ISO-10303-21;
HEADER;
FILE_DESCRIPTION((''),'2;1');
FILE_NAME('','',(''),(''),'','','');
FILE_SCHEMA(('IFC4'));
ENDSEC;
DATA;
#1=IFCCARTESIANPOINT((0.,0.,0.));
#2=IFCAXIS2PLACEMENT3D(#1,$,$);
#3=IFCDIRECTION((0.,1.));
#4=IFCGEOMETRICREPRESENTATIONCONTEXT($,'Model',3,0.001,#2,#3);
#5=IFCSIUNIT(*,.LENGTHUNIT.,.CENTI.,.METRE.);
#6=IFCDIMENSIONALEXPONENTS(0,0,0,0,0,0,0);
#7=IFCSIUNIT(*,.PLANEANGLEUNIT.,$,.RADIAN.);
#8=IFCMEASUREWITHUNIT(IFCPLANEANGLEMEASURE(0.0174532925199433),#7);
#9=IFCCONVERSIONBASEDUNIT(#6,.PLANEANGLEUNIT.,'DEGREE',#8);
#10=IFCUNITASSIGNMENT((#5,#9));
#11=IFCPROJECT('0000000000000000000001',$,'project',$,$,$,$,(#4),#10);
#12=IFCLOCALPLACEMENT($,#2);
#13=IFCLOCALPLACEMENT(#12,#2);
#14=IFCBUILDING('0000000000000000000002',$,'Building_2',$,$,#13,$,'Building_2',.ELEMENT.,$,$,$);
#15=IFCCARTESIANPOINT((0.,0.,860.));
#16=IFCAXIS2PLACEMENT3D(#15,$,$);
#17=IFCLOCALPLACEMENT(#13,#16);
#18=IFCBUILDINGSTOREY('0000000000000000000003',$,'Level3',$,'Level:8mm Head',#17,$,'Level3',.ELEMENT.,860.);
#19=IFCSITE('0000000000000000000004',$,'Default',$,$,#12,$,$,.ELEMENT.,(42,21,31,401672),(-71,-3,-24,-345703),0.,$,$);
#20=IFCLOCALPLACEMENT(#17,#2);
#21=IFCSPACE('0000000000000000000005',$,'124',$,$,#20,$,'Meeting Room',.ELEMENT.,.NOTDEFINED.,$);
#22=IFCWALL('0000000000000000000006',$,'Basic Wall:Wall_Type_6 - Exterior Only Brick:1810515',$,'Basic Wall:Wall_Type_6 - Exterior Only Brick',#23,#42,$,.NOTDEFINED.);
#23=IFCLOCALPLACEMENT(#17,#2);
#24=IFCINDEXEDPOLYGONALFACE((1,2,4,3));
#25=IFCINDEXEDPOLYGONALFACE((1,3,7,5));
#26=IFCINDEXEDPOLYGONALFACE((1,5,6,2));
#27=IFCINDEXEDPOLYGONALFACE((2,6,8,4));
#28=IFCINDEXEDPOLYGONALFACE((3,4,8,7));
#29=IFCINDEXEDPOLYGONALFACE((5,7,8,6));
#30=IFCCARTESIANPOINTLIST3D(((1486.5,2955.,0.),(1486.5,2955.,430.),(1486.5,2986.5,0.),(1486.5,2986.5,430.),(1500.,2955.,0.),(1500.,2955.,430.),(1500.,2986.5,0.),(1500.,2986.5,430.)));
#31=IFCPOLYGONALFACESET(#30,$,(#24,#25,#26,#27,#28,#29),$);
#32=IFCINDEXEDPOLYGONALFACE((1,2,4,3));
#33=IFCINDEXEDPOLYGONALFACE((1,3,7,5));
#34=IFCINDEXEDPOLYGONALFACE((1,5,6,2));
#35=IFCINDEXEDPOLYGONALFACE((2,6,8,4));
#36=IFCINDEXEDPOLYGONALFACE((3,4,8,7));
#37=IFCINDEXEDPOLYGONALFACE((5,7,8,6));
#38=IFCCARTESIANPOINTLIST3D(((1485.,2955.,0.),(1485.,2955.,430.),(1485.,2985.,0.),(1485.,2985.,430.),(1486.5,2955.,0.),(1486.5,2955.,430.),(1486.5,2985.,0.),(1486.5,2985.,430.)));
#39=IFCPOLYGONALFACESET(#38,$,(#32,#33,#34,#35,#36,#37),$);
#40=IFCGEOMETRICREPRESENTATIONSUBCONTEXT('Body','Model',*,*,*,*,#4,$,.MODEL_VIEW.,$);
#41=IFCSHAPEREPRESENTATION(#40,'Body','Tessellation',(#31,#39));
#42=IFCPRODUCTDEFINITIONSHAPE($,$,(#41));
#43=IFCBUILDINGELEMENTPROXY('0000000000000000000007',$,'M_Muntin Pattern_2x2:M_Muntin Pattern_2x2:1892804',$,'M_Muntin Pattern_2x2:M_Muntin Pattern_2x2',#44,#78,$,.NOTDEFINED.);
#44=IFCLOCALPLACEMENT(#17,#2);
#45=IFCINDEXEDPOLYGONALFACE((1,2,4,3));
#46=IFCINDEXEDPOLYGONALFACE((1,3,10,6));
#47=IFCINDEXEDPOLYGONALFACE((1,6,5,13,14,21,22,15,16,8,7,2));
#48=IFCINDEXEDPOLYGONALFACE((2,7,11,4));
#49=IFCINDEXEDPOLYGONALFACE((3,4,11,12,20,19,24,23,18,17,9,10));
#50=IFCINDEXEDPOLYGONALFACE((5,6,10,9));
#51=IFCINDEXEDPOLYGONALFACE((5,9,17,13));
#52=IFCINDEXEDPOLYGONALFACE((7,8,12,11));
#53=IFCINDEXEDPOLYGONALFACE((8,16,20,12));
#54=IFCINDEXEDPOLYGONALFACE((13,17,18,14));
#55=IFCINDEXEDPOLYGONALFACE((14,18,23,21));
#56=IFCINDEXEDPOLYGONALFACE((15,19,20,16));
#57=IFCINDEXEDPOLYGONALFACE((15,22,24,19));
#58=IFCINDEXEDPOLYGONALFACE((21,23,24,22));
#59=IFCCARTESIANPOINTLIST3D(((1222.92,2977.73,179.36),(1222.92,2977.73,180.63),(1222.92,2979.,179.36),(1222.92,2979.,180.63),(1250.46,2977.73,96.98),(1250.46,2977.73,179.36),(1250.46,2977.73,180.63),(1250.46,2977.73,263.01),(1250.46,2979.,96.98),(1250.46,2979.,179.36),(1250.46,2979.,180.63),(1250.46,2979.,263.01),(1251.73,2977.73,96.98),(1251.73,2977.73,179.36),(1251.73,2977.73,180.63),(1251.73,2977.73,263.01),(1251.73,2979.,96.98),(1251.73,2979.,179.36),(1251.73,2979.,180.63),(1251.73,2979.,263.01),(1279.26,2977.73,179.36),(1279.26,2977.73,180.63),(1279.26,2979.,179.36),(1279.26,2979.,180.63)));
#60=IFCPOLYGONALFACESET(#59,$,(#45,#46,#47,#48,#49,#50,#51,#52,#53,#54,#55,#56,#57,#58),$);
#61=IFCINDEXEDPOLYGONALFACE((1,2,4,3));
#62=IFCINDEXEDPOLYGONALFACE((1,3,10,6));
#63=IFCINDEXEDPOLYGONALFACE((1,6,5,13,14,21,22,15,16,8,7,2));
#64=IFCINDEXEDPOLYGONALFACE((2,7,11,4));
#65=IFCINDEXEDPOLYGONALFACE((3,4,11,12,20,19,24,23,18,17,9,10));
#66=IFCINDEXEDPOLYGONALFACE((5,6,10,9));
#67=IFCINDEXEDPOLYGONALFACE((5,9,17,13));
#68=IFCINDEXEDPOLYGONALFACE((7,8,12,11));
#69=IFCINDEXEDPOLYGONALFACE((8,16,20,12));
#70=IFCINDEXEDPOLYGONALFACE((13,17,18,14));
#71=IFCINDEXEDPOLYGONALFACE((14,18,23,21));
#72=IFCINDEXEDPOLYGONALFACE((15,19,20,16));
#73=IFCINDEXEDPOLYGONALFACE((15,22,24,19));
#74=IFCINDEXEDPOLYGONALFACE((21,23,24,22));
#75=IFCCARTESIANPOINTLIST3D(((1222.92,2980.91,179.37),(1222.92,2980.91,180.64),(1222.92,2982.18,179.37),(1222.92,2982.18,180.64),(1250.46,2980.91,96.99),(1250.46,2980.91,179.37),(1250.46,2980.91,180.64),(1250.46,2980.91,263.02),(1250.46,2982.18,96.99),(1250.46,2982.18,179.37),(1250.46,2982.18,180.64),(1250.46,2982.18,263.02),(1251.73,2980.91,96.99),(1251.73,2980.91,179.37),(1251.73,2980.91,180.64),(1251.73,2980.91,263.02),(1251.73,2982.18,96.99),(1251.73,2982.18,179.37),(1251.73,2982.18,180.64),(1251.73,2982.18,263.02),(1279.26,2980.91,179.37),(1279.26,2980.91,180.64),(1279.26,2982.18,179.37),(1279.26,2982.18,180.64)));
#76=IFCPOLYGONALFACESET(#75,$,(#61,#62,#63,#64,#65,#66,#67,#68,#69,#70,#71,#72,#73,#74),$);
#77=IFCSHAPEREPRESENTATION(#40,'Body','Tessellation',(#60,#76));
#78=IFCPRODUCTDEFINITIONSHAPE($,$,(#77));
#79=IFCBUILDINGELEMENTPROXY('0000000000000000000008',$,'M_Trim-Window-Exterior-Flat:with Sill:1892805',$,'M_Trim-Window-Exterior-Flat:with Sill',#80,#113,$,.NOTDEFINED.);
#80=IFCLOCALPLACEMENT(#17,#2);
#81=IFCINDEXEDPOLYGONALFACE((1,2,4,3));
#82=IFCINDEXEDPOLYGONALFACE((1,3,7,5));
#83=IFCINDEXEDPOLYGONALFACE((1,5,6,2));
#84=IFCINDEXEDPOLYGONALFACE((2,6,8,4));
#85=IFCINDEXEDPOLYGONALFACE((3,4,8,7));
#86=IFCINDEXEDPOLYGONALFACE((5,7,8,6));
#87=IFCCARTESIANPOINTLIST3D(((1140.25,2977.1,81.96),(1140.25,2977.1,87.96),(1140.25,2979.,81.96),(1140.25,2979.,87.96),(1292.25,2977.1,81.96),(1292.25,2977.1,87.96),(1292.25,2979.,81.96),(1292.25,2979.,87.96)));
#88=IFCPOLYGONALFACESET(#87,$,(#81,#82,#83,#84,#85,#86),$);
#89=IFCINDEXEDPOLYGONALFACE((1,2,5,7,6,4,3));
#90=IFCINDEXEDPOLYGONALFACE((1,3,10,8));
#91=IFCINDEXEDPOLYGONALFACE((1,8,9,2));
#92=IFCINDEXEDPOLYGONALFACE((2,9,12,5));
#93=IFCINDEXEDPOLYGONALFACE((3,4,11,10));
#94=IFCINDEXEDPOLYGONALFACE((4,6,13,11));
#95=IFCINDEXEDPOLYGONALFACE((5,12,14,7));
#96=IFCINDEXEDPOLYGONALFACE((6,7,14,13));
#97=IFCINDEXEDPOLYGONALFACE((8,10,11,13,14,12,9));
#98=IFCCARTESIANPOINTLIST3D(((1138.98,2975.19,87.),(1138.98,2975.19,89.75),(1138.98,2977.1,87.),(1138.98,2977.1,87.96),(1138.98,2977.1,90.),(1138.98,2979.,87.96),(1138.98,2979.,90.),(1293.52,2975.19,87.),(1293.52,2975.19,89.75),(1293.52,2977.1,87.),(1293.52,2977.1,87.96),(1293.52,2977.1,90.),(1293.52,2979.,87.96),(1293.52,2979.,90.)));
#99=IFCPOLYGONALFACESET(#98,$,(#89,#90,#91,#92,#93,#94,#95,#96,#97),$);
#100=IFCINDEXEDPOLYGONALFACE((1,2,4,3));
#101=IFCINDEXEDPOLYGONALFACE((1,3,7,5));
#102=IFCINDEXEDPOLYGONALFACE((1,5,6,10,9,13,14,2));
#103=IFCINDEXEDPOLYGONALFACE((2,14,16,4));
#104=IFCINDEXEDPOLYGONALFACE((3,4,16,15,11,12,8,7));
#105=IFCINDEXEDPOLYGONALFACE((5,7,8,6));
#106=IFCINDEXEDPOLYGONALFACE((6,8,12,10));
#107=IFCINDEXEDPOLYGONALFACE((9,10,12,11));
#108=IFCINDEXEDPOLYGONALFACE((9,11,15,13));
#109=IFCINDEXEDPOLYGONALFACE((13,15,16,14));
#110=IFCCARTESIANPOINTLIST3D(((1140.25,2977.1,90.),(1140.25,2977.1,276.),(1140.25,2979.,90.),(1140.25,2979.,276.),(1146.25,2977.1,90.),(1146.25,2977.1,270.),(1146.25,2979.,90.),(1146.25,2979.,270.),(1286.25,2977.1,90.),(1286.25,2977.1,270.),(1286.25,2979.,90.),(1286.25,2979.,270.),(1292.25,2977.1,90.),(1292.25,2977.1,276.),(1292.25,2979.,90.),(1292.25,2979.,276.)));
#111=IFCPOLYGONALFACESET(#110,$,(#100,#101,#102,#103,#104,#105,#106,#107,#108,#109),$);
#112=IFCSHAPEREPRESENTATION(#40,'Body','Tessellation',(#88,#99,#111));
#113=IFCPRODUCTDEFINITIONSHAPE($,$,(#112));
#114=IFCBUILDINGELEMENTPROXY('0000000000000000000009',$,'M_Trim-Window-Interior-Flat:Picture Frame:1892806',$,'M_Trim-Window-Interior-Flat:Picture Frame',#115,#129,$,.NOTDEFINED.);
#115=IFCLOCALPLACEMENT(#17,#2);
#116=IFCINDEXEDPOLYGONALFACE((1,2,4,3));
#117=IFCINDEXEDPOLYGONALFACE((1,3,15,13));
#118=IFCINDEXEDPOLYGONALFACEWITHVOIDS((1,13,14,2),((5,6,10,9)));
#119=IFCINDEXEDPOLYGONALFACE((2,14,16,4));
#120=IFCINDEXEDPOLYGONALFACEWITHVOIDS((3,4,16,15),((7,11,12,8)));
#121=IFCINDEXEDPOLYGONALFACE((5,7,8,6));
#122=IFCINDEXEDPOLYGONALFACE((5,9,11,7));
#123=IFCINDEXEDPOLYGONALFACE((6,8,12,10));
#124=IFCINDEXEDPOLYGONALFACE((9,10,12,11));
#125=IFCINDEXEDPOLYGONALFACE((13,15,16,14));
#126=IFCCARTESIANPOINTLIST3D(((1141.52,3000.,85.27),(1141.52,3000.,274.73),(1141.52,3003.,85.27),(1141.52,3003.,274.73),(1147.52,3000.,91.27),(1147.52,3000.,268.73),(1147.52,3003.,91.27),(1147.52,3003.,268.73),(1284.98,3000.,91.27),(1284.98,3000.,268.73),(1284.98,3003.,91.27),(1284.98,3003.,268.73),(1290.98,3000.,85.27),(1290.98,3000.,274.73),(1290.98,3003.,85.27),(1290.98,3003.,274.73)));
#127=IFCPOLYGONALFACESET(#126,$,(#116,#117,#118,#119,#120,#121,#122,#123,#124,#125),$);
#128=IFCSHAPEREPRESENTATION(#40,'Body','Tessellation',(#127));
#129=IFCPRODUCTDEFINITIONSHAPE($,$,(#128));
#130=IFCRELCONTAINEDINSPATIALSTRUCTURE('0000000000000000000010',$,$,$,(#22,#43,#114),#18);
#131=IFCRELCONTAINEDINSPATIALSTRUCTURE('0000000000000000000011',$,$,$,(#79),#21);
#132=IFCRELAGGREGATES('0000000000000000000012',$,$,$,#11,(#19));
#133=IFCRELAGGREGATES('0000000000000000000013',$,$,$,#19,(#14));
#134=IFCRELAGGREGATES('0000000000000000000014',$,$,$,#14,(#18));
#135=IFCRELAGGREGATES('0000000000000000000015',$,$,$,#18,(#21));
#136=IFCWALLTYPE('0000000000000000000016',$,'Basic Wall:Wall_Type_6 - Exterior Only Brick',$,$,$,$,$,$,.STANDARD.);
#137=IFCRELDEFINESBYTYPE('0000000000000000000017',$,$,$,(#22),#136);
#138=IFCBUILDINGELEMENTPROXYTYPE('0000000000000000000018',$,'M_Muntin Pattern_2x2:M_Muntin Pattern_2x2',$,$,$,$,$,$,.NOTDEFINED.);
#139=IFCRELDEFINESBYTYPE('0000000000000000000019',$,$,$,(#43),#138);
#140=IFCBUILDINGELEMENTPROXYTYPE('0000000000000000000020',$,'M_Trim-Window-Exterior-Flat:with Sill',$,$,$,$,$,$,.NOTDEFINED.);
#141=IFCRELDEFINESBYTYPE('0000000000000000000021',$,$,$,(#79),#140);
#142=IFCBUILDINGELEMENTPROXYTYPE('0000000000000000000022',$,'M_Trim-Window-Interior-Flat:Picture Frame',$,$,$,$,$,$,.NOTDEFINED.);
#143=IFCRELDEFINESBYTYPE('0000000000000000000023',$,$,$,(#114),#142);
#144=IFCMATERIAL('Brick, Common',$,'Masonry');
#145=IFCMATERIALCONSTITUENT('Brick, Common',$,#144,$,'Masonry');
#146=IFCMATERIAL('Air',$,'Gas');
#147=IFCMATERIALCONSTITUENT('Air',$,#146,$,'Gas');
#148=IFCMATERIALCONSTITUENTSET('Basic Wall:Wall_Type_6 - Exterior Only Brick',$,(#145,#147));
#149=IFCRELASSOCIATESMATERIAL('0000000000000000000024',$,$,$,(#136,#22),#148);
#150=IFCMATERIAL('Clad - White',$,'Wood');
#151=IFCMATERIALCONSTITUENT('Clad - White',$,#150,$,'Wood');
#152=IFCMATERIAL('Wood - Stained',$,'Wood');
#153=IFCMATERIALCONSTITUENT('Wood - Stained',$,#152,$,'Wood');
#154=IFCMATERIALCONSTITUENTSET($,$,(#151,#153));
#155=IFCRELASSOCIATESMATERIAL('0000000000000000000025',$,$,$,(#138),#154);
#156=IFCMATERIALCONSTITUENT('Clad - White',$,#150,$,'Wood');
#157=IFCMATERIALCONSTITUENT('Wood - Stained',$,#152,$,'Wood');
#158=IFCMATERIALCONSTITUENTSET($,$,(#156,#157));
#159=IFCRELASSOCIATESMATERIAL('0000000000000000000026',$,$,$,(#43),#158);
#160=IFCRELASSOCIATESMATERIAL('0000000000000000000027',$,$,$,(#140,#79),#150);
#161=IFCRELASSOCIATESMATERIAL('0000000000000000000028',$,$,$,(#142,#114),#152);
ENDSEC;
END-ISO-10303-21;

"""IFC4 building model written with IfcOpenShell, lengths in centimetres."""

from ifc_helpers import new_model, entity, si_unit, converted_unit, direction, frame, origin, place, context, subcontext, project, spatial, indexed_curve, outline, extrude, source, transform, mapped, material, constituent, constituent_set, type_object, type_shapes, element, save


model = new_model("IFC4")

# Units and contexts
model_context = context("Model", 3, precision=0.001, world=origin(), true_north=direction((0.0, 1.0)))
body_context = subcontext(model_context, "Body", "Model", "MODEL_VIEW")
ifc_project = project(units=[si_unit("LENGTHUNIT", "METRE", prefix="CENTI"), converted_unit("PLANEANGLEUNIT", "DEGREE", entity("IfcPlaneAngleMeasure", 0.0174532925199433), si_unit("PLANEANGLEUNIT", "RADIAN"), dimensions=[0, 0, 0, 0, 0, 0, 0])], contexts=[model_context])

# Site, building, storey
site_placement = place(None, origin())
site = spatial("IfcSite", under=ifc_project, at=site_placement, Name="Default", CompositionType="ELEMENT", RefLatitude=(42, 21, 31, 401672), RefLongitude=(-71, -3, -24, -345703), RefElevation=0.0)
building_placement = place(site_placement, origin())
building = spatial("IfcBuilding", under=site, at=building_placement, Name="Building_2", LongName="Building_2", CompositionType="ELEMENT")
storey_placement = place(building_placement, frame((0.0, 0.0, 860.0)))
storey = spatial("IfcBuildingStorey", under=building, at=storey_placement, Name="Level3", ObjectType="Level:8mm Head", LongName="Level3", CompositionType="ELEMENT", Elevation=860.0)

# Wall
ifc_material_1 = material(Name="Brick, Common", Category="Masonry")
ifc_constituent_1 = constituent(ifc_material_1, Name="Brick, Common", Category="Masonry")
ifc_material_2 = material(Name="Air", Category="Gas")
ifc_constituent_2 = constituent(ifc_material_2, Name="Air", Category="Gas")
ifc_constituent_set_1 = constituent_set(constituents=[ifc_constituent_1, ifc_constituent_2], Name="Basic Wall:Wall_Type_6 - Exterior Only Brick")
wall_type = type_object("IfcWallType", Name="Basic Wall:Wall_Type_6 - Exterior Only Brick", PredefinedType="STANDARD", material=ifc_constituent_set_1)
wall_1_placement = place(storey_placement, frame((1492.5, 2985.0, 0.0), z_axis=(0.0, 0.0, 1.0), x_axis=(0.0, -1.0, 0.0)))
element("IfcWall", 1, at=wall_1_placement, inside=storey, type_object=wall_type, material=ifc_constituent_set_1, Name="Basic Wall:Wall_Type_6 - Exterior Only Brick:1810515", ObjectType="Basic Wall:Wall_Type_6 - Exterior Only Brick", PredefinedType="NOTDEFINED", context=body_context, shape_type="SweptSolid", body=[
    extrude(outline(indexed_curve([(-6.75, -15.75), (6.75, -15.75), (6.75, 15.75), (-6.75, 15.75), (-6.75, -15.75)], self_intersect=False)), frame((14.25, 0.75, 0.0), z_axis=(0.0, 0.0, 1.0), x_axis=(0.0, -1.0, 0.0)), (0.0, 0.0, 1.0), 430.0),
    extrude(outline(indexed_curve([(-0.75, -15.0), (0.75, -15.0), (0.75, 15.0), (-0.75, 15.0), (-0.75, -15.0)], self_intersect=False)), frame((15.0, -6.75, 0.0), z_axis=(0.0, 0.0, 1.0), x_axis=(0.0, 1.0, 0.0)), (0.0, 0.0, 1.0), 430.0),
])

# Building element proxy
ifc_material_3 = material(Name="Clad - White", Category="Wood")
ifc_constituent_3 = constituent(ifc_material_3, Name="Clad - White", Category="Wood")
ifc_material_4 = material(Name="Wood - Stained", Category="Wood")
ifc_constituent_4 = constituent(ifc_material_4, Name="Wood - Stained", Category="Wood")
ifc_constituent_set_2 = constituent_set(constituents=[ifc_constituent_3, ifc_constituent_4])
ifc_constituent_5 = constituent(ifc_material_3, Name="Clad - White", Category="Wood")
ifc_constituent_6 = constituent(ifc_material_4, Name="Wood - Stained", Category="Wood")
ifc_constituent_set_3 = constituent_set(constituents=[ifc_constituent_5, ifc_constituent_6])
building_element_proxy_type_1 = type_object("IfcBuildingElementProxyType", Name="M_Muntin Pattern_2x2:M_Muntin Pattern_2x2", PredefinedType="NOTDEFINED", material=ifc_constituent_set_3)
shared_shape_1 = source(origin(), body_context, "Body", "SweptSolid", [
    extrude(outline(indexed_curve([(0.64, -0.64), (83.01, -0.64), (83.01, 0.63), (0.64, 0.63), (0.64, 28.17), (-0.63, 28.17), (-0.63, 0.63), (-83.02, 0.63), (-83.02, -0.64), (-0.63, -0.64), (-0.63, -28.17), (0.64, -28.17), (0.64, -0.64)], self_intersect=False)), frame((0.0, 0.95, 83.01), z_axis=(0.0, 1.0, 0.0), x_axis=(0.0, 0.0, 1.0)), (0.0, 0.0, 1.0), 1.27),
    extrude(outline(indexed_curve([(0.64, -0.64), (83.02, -0.64), (83.02, 0.63), (0.64, 0.63), (0.64, 28.17), (-0.63, 28.17), (-0.63, 0.63), (-83.02, 0.63), (-83.02, -0.64), (-0.63, -0.64), (-0.63, -28.17), (0.64, -28.17), (0.64, -0.64)], self_intersect=False)), frame((0.0, -2.22, 83.02), z_axis=(0.0, 1.0, 0.0), x_axis=(0.0, 0.0, 1.0)), (0.0, 0.0, 1.0), 1.27),
])
type_shapes(building_element_proxy_type_1, [shared_shape_1])
proxy_1_placement = place(storey_placement, frame((1251.09, 2979.95, 96.99), z_axis=(0.0, 0.0, 1.0), x_axis=(-1.0, 0.0, 0.0)))
element("IfcBuildingElementProxy", 2, at=proxy_1_placement, inside=storey, type_object=building_element_proxy_type_1, material=ifc_constituent_set_2, Name="M_Muntin Pattern_2x2:M_Muntin Pattern_2x2:1892804", ObjectType="M_Muntin Pattern_2x2:M_Muntin Pattern_2x2", PredefinedType="NOTDEFINED", context=body_context, shape_type="MappedRepresentation", body=[
    mapped(shared_shape_1, transform((0.0, 0.0, 0.0), scale=1.0)),
])

# Shared definitions
space_placement = place(storey_placement, origin())
space = spatial("IfcSpace", under=storey, at=space_placement, Name="124", LongName="Meeting Room", CompositionType="ELEMENT", PredefinedType="NOTDEFINED")

# Building element proxies
building_element_proxy_type_2 = type_object("IfcBuildingElementProxyType", Name="M_Trim-Window-Exterior-Flat:with Sill", PredefinedType="NOTDEFINED", material=ifc_material_3)
shared_shape_2 = source(origin(), body_context, "Body", "SweptSolid", [
    extrude(outline(indexed_curve([(-3.0, -76.0), (3.0, -76.0), (3.0, 76.0), (-3.0, 76.0), (-3.0, -76.0)], self_intersect=False)), frame((0.0, 185.04, 0.0), z_axis=(0.0, 0.0, 1.0), x_axis=(0.0, 1.0, 0.0)), (0.0, 0.0, 1.0), 1.91),
    extrude(outline(indexed_curve([(-1.52, -1.9), (1.23, -1.9), (1.48, 0.0), (1.48, 1.9), (-0.57, 1.9), (-0.57, 0.0), (-1.52, 0.0), (-1.52, -1.9)], self_intersect=False)), frame((-77.27, 181.48, 1.9), z_axis=(1.0, 0.0, 0.0), x_axis=(0.0, -1.0, 0.0)), (0.0, 0.0, 1.0), 154.54),
    extrude(outline(indexed_curve([(-76.0, -94.5), (76.0, -94.5), (76.0, 91.5), (70.0, 91.5), (70.0, -88.5), (-70.0, -88.5), (-70.0, 91.5), (-76.0, 91.5), (-76.0, -94.5)], self_intersect=False)), frame((0.0, 88.5, 0.0)), (0.0, 0.0, 1.0), 1.91),
])
type_shapes(building_element_proxy_type_2, [shared_shape_2])
proxy_2_placement = place(space_placement, frame((1216.25, 2979.0, 270.0), z_axis=(0.0, -1.0, 0.0), x_axis=(-1.0, 0.0, 0.0)))
element("IfcBuildingElementProxy", 3, at=proxy_2_placement, inside=space, type_object=building_element_proxy_type_2, material=ifc_material_3, Name="M_Trim-Window-Exterior-Flat:with Sill:1892805", ObjectType="M_Trim-Window-Exterior-Flat:with Sill", PredefinedType="NOTDEFINED", context=body_context, shape_type="MappedRepresentation", body=[
    mapped(shared_shape_2, transform((0.0, 0.0, 0.0), scale=1.0)),
])
building_element_proxy_type_3 = type_object("IfcBuildingElementProxyType", Name="M_Trim-Window-Interior-Flat:Picture Frame", PredefinedType="NOTDEFINED", material=ifc_material_4)
shared_shape_3 = source(origin(), body_context, "Body", "SweptSolid", [
    extrude(outline(indexed_curve([(-94.73, -74.73), (94.73, -74.73), (94.73, 74.73), (-94.73, 74.73), (-94.73, -74.73)], self_intersect=False), holes=[indexed_curve([(-88.73, -68.73), (-88.73, 68.73), (88.73, 68.73), (88.73, -68.73), (-88.73, -68.73)], self_intersect=False)]), frame((0.0, 90.0, 0.0), z_axis=(0.0, 0.0, 1.0), x_axis=(0.0, 1.0, 0.0)), (0.0, 0.0, 1.0), 3.0),
])
type_shapes(building_element_proxy_type_3, [shared_shape_3])
proxy_3_placement = place(storey_placement, frame((1216.25, 3000.0, 270.0), z_axis=(0.0, 1.0, 0.0), x_axis=(1.0, 0.0, 0.0)))
element("IfcBuildingElementProxy", 4, at=proxy_3_placement, inside=storey, type_object=building_element_proxy_type_3, material=ifc_material_4, Name="M_Trim-Window-Interior-Flat:Picture Frame:1892806", ObjectType="M_Trim-Window-Interior-Flat:Picture Frame", PredefinedType="NOTDEFINED", context=body_context, shape_type="MappedRepresentation", body=[
    mapped(shared_shape_3, transform((0.0, 0.0, 0.0), scale=1.0)),
])

save(model, "model.ifc")
